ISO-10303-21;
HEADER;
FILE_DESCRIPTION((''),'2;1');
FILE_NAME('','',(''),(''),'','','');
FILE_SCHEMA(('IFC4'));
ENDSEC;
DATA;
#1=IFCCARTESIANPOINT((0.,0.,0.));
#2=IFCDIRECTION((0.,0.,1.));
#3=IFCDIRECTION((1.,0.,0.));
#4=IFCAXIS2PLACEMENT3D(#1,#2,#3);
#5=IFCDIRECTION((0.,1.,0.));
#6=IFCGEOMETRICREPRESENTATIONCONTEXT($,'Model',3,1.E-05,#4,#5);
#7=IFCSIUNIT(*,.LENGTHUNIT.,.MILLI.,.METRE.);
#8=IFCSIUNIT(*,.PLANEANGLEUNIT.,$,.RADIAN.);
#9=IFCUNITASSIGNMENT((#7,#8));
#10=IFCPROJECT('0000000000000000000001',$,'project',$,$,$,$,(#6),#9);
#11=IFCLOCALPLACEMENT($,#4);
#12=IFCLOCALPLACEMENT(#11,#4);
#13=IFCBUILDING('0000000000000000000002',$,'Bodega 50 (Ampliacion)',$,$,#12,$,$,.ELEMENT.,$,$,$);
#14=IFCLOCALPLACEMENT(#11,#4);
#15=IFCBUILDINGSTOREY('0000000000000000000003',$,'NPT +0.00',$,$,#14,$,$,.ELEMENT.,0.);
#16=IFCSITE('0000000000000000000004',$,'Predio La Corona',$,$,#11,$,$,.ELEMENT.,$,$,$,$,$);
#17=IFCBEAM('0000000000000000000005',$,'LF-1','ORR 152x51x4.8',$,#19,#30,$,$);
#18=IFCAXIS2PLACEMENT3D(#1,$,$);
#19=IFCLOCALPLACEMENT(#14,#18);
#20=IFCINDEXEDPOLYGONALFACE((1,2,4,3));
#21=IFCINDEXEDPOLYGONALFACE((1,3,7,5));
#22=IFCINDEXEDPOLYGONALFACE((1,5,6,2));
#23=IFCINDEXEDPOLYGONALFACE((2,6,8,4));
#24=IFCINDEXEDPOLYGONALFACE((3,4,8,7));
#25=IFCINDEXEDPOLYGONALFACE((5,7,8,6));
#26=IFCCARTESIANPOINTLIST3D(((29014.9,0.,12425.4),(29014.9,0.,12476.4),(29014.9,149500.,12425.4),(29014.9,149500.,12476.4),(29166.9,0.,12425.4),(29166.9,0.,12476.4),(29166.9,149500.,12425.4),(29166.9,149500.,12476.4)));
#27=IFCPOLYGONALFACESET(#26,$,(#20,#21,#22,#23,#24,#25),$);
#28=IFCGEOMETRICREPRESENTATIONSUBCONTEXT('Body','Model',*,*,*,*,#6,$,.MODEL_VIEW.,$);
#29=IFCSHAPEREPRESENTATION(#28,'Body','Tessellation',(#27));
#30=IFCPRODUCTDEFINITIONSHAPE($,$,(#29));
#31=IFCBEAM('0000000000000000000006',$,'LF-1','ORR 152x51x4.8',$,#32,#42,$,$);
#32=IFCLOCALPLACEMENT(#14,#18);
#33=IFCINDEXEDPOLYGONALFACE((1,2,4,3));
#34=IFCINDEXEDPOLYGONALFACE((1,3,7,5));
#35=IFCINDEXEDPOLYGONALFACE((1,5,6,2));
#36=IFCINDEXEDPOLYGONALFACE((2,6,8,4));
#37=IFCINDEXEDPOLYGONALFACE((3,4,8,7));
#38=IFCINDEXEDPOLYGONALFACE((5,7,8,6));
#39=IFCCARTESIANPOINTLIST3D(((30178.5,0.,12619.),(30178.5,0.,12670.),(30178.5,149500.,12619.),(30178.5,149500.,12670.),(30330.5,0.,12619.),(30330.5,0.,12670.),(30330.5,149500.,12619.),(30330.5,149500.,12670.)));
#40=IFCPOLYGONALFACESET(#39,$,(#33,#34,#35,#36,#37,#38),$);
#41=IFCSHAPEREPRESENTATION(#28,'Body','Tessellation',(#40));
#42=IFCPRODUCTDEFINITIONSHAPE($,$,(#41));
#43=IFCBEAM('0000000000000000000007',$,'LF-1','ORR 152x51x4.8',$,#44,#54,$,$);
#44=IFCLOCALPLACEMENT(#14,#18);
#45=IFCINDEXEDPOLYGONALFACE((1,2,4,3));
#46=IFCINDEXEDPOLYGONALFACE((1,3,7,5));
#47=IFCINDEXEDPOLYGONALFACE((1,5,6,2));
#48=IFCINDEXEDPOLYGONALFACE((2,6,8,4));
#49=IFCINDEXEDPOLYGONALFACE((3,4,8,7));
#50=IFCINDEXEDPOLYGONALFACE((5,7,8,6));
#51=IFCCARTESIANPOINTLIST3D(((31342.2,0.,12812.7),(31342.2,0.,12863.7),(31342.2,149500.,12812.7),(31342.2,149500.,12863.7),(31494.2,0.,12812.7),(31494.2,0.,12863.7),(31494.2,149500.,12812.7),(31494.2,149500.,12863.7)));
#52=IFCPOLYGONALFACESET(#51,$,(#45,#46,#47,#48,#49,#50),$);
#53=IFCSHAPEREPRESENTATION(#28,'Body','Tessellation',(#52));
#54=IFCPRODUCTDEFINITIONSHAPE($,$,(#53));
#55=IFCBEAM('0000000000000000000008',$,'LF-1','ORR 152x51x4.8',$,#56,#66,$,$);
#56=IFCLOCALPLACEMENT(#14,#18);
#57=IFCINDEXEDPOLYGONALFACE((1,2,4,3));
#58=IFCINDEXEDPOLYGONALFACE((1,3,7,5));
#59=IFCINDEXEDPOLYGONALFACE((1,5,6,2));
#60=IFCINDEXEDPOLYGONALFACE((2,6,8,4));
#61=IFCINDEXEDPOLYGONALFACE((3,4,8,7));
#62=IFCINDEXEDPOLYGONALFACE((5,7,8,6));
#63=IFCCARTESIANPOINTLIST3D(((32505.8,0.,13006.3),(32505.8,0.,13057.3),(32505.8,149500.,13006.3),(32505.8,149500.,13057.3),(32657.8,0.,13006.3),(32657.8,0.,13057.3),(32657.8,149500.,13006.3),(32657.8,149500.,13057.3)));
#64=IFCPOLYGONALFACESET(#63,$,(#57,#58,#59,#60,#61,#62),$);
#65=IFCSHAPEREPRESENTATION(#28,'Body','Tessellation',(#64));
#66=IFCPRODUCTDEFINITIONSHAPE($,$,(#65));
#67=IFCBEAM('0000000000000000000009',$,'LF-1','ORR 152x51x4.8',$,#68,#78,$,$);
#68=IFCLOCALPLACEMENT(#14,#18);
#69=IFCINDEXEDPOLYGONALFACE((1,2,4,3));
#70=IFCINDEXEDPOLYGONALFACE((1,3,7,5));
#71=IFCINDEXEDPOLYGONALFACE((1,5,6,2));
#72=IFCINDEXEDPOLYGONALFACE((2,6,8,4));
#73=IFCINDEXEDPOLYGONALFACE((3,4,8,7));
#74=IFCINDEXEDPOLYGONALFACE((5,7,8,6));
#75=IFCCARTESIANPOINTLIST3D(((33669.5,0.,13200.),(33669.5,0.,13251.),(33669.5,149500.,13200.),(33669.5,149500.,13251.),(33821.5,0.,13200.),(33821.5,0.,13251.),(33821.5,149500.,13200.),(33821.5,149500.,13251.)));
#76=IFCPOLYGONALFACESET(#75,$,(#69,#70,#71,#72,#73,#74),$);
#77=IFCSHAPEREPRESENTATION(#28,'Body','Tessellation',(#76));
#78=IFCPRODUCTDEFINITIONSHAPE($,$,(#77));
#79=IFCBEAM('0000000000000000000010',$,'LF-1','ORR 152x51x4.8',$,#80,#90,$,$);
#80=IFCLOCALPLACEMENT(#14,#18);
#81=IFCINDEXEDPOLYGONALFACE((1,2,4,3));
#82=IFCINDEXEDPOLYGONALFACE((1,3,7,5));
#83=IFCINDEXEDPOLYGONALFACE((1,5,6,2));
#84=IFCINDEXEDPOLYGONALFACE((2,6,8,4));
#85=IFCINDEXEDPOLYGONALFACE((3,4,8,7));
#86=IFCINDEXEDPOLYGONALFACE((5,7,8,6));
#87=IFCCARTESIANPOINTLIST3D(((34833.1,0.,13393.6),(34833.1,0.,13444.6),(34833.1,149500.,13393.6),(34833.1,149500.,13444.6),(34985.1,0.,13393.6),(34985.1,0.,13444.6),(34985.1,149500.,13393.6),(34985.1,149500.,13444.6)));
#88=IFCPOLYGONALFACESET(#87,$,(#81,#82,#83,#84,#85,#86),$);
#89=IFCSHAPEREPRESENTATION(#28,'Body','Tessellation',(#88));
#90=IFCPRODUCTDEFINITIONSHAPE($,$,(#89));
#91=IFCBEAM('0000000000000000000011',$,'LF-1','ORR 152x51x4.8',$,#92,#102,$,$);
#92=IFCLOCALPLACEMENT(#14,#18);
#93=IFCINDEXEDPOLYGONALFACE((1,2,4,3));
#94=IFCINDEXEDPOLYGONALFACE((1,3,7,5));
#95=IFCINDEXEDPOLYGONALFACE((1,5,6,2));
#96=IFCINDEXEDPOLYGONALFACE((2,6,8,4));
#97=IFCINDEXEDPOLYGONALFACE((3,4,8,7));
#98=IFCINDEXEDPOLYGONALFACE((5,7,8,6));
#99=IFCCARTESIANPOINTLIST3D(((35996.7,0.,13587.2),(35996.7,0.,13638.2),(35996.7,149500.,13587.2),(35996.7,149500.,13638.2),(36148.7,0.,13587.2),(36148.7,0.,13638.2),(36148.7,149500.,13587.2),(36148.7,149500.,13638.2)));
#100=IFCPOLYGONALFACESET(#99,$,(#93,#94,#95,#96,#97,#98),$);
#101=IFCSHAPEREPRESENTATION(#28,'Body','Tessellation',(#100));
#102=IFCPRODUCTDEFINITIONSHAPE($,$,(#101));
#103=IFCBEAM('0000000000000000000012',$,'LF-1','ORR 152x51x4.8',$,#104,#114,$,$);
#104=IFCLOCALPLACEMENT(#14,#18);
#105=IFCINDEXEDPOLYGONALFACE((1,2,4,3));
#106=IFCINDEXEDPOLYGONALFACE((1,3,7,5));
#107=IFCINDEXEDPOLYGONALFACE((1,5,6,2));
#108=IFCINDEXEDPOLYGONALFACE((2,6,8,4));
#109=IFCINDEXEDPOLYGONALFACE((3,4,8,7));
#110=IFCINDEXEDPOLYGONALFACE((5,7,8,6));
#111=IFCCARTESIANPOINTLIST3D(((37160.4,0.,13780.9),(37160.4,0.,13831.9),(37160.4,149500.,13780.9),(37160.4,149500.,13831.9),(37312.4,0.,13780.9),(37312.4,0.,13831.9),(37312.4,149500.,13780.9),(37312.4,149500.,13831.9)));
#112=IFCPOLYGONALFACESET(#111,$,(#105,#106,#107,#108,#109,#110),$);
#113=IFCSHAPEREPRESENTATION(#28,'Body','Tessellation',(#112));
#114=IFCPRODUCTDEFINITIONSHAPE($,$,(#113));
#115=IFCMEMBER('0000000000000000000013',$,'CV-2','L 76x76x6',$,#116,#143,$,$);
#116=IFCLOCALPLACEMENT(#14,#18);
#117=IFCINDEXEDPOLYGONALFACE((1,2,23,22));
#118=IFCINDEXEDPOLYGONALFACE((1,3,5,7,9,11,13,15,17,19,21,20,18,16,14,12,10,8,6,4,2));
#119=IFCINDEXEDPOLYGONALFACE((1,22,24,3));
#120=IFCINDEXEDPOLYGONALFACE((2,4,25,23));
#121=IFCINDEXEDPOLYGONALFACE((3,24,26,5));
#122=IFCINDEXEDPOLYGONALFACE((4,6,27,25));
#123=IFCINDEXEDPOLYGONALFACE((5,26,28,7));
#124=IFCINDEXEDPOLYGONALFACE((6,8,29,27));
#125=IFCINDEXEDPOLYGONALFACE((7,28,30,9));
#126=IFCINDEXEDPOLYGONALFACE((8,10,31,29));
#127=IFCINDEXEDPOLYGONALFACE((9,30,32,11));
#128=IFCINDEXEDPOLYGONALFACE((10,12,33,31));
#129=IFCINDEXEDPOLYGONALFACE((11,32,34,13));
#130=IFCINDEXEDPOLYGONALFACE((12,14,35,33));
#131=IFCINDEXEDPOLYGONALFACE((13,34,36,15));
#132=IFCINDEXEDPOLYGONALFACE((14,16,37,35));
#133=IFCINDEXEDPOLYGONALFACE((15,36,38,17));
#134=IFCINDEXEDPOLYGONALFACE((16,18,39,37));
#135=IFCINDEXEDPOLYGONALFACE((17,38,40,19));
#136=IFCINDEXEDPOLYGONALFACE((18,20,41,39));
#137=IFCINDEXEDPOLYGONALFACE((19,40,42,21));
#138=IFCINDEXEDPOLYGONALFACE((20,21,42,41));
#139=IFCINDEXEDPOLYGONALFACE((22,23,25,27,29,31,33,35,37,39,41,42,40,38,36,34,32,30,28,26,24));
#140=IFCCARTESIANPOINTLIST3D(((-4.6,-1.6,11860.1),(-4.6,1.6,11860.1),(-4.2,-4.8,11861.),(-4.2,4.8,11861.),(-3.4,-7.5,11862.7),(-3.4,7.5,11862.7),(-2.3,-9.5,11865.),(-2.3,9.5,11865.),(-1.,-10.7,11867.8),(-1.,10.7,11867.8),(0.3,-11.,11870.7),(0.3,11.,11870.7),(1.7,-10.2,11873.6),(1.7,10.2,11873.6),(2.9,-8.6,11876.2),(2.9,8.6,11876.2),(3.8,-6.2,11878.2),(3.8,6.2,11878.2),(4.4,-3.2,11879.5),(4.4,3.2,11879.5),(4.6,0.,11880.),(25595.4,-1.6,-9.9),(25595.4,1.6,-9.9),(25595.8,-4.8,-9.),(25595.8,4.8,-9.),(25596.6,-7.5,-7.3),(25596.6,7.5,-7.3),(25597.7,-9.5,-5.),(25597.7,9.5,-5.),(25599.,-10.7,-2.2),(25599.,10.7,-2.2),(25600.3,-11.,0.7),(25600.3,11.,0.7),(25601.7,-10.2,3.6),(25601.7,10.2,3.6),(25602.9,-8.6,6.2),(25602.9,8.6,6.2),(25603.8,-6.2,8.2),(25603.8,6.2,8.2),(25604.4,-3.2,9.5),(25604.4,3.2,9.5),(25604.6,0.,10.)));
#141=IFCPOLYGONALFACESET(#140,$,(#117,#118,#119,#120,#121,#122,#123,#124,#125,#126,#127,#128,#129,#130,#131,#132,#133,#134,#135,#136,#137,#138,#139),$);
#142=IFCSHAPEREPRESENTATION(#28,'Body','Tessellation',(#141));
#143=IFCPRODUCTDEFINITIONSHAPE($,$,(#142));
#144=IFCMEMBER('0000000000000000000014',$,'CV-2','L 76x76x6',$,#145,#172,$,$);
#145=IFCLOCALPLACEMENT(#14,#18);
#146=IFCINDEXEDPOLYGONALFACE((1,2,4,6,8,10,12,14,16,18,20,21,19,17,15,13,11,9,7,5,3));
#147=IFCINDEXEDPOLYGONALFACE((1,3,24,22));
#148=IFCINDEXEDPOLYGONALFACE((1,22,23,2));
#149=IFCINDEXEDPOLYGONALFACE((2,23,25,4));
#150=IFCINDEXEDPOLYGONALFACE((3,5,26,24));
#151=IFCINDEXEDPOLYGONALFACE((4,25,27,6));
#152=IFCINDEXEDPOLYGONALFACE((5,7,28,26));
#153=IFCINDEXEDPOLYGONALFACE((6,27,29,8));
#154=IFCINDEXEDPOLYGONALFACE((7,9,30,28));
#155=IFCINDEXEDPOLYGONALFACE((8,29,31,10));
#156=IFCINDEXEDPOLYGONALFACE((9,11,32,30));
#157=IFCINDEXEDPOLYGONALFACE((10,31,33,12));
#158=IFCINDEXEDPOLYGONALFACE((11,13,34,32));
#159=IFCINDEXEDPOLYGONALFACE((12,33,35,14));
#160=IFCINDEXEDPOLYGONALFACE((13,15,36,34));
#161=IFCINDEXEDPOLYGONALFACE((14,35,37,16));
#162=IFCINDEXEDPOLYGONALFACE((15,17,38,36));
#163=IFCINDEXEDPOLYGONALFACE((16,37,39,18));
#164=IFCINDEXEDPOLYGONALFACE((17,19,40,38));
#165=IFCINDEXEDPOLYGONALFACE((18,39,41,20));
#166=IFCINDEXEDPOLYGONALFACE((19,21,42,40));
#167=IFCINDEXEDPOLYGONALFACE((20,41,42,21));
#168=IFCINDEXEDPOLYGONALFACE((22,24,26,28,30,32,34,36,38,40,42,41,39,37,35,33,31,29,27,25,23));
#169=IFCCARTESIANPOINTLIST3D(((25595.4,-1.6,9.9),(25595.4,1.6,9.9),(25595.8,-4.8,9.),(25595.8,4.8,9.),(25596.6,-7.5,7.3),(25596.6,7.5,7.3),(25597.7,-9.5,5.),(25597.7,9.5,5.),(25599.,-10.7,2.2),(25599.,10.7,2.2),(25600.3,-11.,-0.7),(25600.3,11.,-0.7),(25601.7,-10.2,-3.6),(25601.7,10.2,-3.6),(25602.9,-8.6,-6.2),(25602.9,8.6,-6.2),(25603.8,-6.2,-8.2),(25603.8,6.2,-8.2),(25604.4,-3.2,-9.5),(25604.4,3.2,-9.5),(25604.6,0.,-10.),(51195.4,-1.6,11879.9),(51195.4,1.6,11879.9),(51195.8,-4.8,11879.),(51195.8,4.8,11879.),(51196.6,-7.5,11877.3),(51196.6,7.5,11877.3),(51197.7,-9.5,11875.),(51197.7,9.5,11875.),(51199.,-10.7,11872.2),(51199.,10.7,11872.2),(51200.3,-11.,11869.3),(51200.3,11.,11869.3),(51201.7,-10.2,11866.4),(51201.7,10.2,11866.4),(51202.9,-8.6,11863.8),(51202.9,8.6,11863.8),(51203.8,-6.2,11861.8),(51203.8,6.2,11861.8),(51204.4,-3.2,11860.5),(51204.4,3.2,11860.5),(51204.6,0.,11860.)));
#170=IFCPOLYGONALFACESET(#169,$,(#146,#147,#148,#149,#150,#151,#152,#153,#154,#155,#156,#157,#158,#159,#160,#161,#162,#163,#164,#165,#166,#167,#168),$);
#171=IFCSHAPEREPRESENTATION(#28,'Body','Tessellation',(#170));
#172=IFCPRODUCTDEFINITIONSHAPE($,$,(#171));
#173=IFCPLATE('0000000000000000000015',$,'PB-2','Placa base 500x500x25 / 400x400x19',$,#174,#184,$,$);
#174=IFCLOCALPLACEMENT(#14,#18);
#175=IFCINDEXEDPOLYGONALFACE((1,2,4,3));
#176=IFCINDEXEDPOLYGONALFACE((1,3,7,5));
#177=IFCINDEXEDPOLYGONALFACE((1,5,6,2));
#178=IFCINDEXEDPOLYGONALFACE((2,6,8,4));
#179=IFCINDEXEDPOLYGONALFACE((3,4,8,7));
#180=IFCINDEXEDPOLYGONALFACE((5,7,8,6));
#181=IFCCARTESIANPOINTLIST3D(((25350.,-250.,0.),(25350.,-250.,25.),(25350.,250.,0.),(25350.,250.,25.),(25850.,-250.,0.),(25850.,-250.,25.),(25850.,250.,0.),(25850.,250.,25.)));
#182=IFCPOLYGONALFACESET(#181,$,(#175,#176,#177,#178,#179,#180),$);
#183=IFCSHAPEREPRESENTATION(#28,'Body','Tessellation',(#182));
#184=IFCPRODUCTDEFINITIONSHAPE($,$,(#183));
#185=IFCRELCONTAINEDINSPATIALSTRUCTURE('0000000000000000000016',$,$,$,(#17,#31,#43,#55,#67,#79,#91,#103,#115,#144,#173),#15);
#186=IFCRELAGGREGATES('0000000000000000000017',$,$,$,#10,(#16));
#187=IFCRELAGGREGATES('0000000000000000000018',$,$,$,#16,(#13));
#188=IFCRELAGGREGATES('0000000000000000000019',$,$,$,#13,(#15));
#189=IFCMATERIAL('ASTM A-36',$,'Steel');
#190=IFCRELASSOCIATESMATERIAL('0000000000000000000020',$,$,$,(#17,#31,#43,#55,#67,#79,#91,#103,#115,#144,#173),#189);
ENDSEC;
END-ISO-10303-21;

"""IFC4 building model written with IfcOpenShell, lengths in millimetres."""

from ifc_helpers import new_model, si_unit, direction, frame, origin_with_axes, origin_2d, place, context, subcontext, project, spatial, rectangle, circle, extrude, material, element, save


model = new_model("IFC4")

# Units and contexts
model_context = context("Model", 3, precision=1e-05, world=origin_with_axes(), true_north=direction((0.0, 1.0, 0.0)))
body_context = subcontext(model_context, "Body", "Model", "MODEL_VIEW")
ifc_project = project(units=[si_unit("LENGTHUNIT", "METRE", prefix="MILLI"), si_unit("PLANEANGLEUNIT", "RADIAN")], contexts=[model_context])

# Site, building, storey
site_placement = place(None, origin_with_axes())
site = spatial("IfcSite", under=ifc_project, at=site_placement, Name="Predio La Corona", CompositionType="ELEMENT")
building_placement = place(site_placement, origin_with_axes())
building = spatial("IfcBuilding", under=site, at=building_placement, Name="Bodega 50 (Ampliacion)", CompositionType="ELEMENT")
storey_placement = place(site_placement, origin_with_axes())
storey = spatial("IfcBuildingStorey", under=building, at=storey_placement, Name="NPT +0.00", CompositionType="ELEMENT", Elevation=0.0)

# Shared definitions
ifc_material = material(Name="ASTM A-36", Category="Steel")

# Beams
for number, where, z_axis, x_axis, name in (
    (1, (29090.9, 0.0, 12450.9), (0.0, 1.0, 0.0), (0.0, 0.0, 1.0), "LF-1"),
    (2, (30254.5, 0.0, 12644.5), (0.0, 1.0, 0.0), (0.0, 0.0, 1.0), "LF-1"),
    (3, (31418.2, 0.0, 12838.2), (0.0, 1.0, 0.0), (0.0, 0.0, 1.0), "LF-1"),
    (4, (32581.8, 0.0, 13031.8), (0.0, 1.0, 0.0), (0.0, 0.0, 1.0), "LF-1"),
    (5, (33745.5, 0.0, 13225.5), (0.0, 1.0, 0.0), (0.0, 0.0, 1.0), "LF-1"),
    (6, (34909.1, 0.0, 13419.1), (0.0, 1.0, 0.0), (0.0, 0.0, 1.0), "LF-1"),
    (7, (36072.7, 0.0, 13612.7), (0.0, 1.0, 0.0), (0.0, 0.0, 1.0), "LF-1"),
    (8, (37236.4, 0.0, 13806.4), (0.0, 1.0, 0.0), (0.0, 0.0, 1.0), "LF-1"),
):
    element("IfcBeam", number, at=place(storey_placement, frame(where, z_axis=z_axis, x_axis=x_axis)), inside=storey, material=ifc_material, Name=name, Description="ORR 152x51x4.8", context=body_context, shape_type="SweptSolid", body=[
        extrude(rectangle(XDim=51.0, YDim=152.0, at=origin_2d()), origin_with_axes(), (0.0, 0.0, 1.0), 149500.0),
    ])

# Members
for number, where, z_axis, x_axis, name in (
    (9, (25600.0, 0.0, 0.0), (-0.907222, 0.0, 0.420653), (0.420653, 0.0, 0.907222), "CV-2"),
    (10, (25600.0, 0.0, 0.0), (0.907222, 0.0, 0.420653), (0.420653, 0.0, -0.907222), "CV-2"),
):
    element("IfcMember", number, at=place(storey_placement, frame(where, z_axis=z_axis, x_axis=x_axis)), inside=storey, material=ifc_material, Name=name, Description="L 76x76x6", context=body_context, shape_type="SweptSolid", body=[
        extrude(circle(Radius=11.0, at=origin_2d()), origin_with_axes(), (0.0, 0.0, 1.0), 28218.0),
    ])

# Plate
plate_placement = place(storey_placement, frame((25600.0, 0.0, 0.0), z_axis=(0.0, 0.0, 1.0), x_axis=(1.0, 0.0, 0.0)))
element("IfcPlate", 11, at=plate_placement, inside=storey, material=ifc_material, Name="PB-2", Description="Placa base 500x500x25 / 400x400x19", context=body_context, shape_type="SweptSolid", body=[
    extrude(rectangle(XDim=500.0, YDim=500.0, at=origin_2d()), origin_with_axes(), (0.0, 0.0, 1.0), 25.0),
])

save(model, "model.ifc")
